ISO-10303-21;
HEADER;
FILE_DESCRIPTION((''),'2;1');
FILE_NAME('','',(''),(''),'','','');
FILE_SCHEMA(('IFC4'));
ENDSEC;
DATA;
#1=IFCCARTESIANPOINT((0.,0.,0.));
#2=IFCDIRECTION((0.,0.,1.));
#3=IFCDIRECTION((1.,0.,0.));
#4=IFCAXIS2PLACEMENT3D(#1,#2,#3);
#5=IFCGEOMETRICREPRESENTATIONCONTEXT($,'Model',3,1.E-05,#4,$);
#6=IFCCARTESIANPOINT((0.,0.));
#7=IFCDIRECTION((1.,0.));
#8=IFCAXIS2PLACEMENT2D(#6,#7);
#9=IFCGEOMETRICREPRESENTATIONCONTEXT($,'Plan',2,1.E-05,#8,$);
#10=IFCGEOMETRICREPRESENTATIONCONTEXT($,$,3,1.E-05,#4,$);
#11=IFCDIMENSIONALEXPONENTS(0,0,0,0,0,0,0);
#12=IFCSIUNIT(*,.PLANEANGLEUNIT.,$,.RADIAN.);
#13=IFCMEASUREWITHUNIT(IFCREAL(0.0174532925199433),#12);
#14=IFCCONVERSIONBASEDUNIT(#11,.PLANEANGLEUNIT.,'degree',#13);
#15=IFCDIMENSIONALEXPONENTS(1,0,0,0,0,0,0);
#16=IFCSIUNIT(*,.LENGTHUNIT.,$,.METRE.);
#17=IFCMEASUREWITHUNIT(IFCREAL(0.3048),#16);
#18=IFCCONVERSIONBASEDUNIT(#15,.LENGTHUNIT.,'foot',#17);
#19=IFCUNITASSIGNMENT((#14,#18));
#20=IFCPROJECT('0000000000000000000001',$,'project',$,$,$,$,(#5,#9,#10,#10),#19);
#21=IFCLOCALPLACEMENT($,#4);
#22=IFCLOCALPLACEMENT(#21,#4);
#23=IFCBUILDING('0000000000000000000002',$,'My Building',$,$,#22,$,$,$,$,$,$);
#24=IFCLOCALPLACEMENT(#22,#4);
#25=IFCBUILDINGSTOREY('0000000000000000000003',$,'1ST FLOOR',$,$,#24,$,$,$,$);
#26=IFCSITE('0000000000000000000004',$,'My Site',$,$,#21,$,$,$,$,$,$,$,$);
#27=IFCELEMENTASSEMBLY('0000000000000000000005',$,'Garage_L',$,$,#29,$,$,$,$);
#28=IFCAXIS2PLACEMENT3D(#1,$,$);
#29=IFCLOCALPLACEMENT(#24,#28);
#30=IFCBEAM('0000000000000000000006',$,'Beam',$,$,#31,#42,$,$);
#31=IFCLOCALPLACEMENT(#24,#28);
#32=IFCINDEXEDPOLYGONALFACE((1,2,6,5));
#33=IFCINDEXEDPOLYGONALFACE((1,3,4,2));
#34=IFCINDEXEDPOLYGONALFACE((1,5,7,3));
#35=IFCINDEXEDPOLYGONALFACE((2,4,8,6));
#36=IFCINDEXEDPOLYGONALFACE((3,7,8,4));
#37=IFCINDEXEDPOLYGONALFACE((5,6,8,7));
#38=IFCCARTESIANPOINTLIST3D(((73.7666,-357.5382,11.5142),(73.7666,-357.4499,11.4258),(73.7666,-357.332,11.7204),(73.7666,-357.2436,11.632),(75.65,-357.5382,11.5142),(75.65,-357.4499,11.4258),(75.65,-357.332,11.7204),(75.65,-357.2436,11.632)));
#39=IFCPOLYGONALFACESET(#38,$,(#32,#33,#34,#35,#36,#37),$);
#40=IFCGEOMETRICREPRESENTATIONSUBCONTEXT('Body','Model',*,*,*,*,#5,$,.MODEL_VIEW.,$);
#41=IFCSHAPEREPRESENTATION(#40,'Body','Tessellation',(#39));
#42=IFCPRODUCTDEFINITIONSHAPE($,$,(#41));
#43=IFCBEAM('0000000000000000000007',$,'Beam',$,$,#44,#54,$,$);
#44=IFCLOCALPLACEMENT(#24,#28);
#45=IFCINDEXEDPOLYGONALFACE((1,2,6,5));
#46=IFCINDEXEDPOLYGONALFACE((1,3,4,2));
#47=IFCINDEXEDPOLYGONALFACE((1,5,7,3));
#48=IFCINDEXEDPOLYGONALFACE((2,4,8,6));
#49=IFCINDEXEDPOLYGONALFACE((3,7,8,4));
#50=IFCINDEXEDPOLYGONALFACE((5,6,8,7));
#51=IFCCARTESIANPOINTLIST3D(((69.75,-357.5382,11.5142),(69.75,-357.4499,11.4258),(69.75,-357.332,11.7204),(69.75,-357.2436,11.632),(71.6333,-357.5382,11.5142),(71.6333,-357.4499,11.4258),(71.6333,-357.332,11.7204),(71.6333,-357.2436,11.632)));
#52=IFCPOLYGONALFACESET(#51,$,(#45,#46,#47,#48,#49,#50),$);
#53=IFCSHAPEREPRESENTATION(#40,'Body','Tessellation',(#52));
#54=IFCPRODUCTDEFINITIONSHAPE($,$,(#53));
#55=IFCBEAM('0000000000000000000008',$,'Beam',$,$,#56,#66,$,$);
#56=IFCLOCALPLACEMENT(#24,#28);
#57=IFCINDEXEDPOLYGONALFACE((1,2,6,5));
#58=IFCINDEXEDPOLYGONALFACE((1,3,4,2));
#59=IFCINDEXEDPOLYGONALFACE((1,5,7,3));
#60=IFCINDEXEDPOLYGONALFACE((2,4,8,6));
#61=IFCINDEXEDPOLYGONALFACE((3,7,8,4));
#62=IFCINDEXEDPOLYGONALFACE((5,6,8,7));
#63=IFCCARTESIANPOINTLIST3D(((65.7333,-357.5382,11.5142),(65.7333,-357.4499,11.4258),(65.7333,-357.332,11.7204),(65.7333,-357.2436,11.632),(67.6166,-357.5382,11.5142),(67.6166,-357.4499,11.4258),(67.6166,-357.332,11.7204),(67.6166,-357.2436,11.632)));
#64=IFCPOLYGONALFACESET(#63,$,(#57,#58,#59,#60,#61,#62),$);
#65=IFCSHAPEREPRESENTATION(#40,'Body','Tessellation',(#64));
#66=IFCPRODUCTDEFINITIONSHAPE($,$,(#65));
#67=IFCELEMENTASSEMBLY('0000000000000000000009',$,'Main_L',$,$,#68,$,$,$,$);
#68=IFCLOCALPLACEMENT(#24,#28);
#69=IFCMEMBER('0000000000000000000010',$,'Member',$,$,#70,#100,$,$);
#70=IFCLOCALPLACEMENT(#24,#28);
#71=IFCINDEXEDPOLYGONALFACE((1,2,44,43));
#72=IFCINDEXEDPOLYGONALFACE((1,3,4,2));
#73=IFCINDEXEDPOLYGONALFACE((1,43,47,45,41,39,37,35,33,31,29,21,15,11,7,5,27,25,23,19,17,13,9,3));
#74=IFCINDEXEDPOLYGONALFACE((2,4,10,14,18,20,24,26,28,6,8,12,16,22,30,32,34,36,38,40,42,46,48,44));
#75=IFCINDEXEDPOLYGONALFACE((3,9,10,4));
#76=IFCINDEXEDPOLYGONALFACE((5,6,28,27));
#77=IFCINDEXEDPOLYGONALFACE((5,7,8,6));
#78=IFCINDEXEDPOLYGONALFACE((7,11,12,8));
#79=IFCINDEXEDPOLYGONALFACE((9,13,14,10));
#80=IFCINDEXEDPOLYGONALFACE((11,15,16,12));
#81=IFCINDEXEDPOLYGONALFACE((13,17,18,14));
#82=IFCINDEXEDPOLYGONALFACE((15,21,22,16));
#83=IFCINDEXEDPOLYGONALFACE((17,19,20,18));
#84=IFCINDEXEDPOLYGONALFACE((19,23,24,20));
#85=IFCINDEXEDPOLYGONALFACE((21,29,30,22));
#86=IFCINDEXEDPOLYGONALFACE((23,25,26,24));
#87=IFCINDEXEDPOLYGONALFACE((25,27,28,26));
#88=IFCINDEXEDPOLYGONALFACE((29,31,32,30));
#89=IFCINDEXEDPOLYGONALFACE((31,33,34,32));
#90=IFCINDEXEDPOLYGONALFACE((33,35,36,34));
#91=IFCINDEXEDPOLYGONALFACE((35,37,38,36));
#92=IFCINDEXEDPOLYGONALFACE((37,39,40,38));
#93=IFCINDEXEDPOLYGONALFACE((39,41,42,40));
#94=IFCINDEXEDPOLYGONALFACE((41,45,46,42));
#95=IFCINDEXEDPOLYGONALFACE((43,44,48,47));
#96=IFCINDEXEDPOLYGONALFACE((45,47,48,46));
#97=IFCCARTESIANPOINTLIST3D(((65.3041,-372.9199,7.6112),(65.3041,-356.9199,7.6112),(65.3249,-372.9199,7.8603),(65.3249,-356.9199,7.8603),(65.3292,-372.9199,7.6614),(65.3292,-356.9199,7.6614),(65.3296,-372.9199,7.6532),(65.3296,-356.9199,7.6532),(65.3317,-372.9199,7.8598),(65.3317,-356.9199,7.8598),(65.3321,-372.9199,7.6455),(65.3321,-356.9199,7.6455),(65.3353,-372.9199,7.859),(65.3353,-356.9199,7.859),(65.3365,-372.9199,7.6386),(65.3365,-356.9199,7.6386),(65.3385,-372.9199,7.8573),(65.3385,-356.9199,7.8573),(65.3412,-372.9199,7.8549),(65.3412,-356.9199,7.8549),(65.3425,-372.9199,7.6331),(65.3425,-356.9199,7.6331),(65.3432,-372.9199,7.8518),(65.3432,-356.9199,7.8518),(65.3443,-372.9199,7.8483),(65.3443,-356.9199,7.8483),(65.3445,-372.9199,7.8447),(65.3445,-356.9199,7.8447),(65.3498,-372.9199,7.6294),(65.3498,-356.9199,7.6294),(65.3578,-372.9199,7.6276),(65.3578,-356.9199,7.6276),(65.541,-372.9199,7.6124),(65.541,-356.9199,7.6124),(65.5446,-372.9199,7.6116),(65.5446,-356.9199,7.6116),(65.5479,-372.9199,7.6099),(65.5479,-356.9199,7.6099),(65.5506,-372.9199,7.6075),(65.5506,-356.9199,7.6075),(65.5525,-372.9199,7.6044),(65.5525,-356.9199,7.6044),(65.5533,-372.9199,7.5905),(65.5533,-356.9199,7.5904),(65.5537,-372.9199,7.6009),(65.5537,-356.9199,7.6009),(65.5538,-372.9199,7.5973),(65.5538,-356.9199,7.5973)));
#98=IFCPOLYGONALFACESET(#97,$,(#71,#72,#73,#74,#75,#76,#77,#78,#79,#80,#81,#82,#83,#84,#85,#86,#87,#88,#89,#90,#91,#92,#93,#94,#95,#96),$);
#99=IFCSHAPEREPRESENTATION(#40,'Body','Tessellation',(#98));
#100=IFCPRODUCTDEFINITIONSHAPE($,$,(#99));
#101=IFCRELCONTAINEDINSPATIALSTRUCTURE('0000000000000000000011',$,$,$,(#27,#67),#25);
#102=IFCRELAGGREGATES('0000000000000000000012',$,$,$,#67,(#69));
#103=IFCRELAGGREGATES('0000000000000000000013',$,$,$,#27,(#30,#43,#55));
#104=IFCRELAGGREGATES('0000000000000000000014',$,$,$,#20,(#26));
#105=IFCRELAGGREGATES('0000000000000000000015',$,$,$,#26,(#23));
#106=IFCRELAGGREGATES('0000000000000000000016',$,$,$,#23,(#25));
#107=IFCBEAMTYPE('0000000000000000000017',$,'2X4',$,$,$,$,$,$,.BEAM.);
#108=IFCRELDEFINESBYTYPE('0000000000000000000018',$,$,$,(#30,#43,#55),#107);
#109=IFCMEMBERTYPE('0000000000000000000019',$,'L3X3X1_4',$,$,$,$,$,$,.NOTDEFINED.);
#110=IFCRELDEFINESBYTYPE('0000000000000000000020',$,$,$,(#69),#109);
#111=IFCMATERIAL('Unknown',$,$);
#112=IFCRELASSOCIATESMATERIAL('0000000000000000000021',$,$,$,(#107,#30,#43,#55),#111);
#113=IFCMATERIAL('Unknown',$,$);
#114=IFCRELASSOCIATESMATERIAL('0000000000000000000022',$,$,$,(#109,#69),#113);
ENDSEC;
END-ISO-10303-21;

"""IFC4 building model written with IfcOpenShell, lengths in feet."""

from ifc_helpers import new_model, entity, si_unit, converted_unit, frame, origin_with_axes, origin_2d_with_axis, place, context, subcontext, project, spatial, rectangle, l_section, extrude, material, material_profile, profile_set, profile_usage, type_object, element, aggregate, save


model = new_model("IFC4")

# Units and contexts
model_context = context("Model", 3, precision=1e-05, world=origin_with_axes())
plan_context = context("Plan", 2, precision=1e-05, world=origin_2d_with_axis())
context_of_model = context(None, 3, precision=1e-05, world=origin_with_axes())
body_context = subcontext(model_context, "Body", "Model", "MODEL_VIEW")
ifc_project = project(units=[converted_unit("PLANEANGLEUNIT", "degree", entity("IfcReal", 0.0174532925199433), si_unit("PLANEANGLEUNIT", "RADIAN"), dimensions=[0, 0, 0, 0, 0, 0, 0]), converted_unit("LENGTHUNIT", "foot", entity("IfcReal", 0.3048), si_unit("LENGTHUNIT", "METRE"), dimensions=[1, 0, 0, 0, 0, 0, 0])], contexts=[model_context, plan_context, context_of_model, context_of_model])

# Site, building, storey
site_placement = place(None, origin_with_axes())
site = spatial("IfcSite", under=ifc_project, at=site_placement, Name="My Site")
building_placement = place(site_placement, origin_with_axes())
building = spatial("IfcBuilding", under=site, at=building_placement, Name="My Building")
storey_placement = place(building_placement, origin_with_axes())
storey = spatial("IfcBuildingStorey", under=building, at=storey_placement, Name="1ST FLOOR")

# Element assembly, beams
assembly_1_placement = place(storey_placement, origin_with_axes())
assembly_1 = element("IfcElementAssembly", 1, at=assembly_1_placement, inside=storey, Name="Garage_L")
ifc_material_1 = material(Name="Unknown")
ifc_material_profile_1 = material_profile(ifc_material_1, rectangle(XDim=0.125, YDim=0.2917))
ifc_profile_set_1 = profile_set([ifc_material_profile_1])
ifc_profile_usage_1 = profile_usage(ifc_profile_set_1, cardinal=5)
beam_type_1 = type_object("IfcBeamType", Name="2X4", PredefinedType="BEAM", material=ifc_profile_set_1)
beam_1_placement = place(assembly_1_placement, frame((75.65, -357.3909, 11.5731), z_axis=(-1.0, 0.0, 0.0), x_axis=(0.0, 0.707107, -0.707107)))
beam_1 = element("IfcBeam", 2, at=beam_1_placement, type_object=beam_type_1, material=ifc_profile_usage_1, Name="Beam", context=body_context, shape_type="SweptSolid", body=[
    extrude(rectangle(XDim=0.125, YDim=0.2917), origin_with_axes(), (0.0, 0.0, 1.0), 1.8833),
])
ifc_profile_usage_2 = profile_usage(ifc_profile_set_1, cardinal=5)
beam_2_placement = place(assembly_1_placement, frame((71.6333, -357.3909, 11.5731), z_axis=(-1.0, 0.0, 0.0), x_axis=(0.0, 0.707107, -0.707107)))
beam_2 = element("IfcBeam", 3, at=beam_2_placement, type_object=beam_type_1, material=ifc_profile_usage_2, Name="Beam", context=body_context, shape_type="SweptSolid", body=[
    extrude(rectangle(XDim=0.125, YDim=0.2917), origin_with_axes(), (0.0, 0.0, 1.0), 1.8833),
])
ifc_profile_usage_3 = profile_usage(ifc_profile_set_1, cardinal=5)
beam_3_placement = place(assembly_1_placement, frame((67.6166, -357.3909, 11.5731), z_axis=(-1.0, 0.0, 0.0), x_axis=(0.0, 0.707107, -0.707107)))
beam_3 = element("IfcBeam", 4, at=beam_3_placement, type_object=beam_type_1, material=ifc_profile_usage_3, Name="Beam", context=body_context, shape_type="SweptSolid", body=[
    extrude(rectangle(XDim=0.125, YDim=0.2917), origin_with_axes(), (0.0, 0.0, 1.0), 1.8833),
])

# Element assembly, member
assembly_2_placement = place(storey_placement, origin_with_axes())
assembly_2 = element("IfcElementAssembly", 5, at=assembly_2_placement, inside=storey, Name="Main_L")
ifc_material_2 = material(Name="Unknown")
ifc_material_profile_2 = material_profile(ifc_material_2, l_section(Depth=0.25, Width=0.25, Thickness=0.0208, FilletRadius=0.0312, EdgeRadius=0.014))
ifc_profile_set_2 = profile_set([ifc_material_profile_2])
ifc_profile_usage_4 = profile_usage(ifc_profile_set_2, cardinal=5)
member_type = type_object("IfcMemberType", Name="L3X3X1_4", PredefinedType="NOTDEFINED", material=ifc_profile_set_2)
member_placement = place(assembly_2_placement, frame((65.4391, -356.9199, 7.7254), z_axis=(0.0, -1.0, 0.0), x_axis=(0.996551, 0.0, -0.082982)))
member = element("IfcMember", 6, at=member_placement, type_object=member_type, material=ifc_profile_usage_4, Name="Member", context=body_context, shape_type="SweptSolid", body=[
    extrude(l_section(Depth=0.25, Width=0.25, Thickness=0.0208, FilletRadius=0.0312, EdgeRadius=0.014), origin_with_axes(), (0.0, 0.0, 1.0), 16.0),
])
aggregate(assembly_2, [member])

aggregate(assembly_1, [beam_1, beam_2, beam_3])

save(model, "model.ifc")
